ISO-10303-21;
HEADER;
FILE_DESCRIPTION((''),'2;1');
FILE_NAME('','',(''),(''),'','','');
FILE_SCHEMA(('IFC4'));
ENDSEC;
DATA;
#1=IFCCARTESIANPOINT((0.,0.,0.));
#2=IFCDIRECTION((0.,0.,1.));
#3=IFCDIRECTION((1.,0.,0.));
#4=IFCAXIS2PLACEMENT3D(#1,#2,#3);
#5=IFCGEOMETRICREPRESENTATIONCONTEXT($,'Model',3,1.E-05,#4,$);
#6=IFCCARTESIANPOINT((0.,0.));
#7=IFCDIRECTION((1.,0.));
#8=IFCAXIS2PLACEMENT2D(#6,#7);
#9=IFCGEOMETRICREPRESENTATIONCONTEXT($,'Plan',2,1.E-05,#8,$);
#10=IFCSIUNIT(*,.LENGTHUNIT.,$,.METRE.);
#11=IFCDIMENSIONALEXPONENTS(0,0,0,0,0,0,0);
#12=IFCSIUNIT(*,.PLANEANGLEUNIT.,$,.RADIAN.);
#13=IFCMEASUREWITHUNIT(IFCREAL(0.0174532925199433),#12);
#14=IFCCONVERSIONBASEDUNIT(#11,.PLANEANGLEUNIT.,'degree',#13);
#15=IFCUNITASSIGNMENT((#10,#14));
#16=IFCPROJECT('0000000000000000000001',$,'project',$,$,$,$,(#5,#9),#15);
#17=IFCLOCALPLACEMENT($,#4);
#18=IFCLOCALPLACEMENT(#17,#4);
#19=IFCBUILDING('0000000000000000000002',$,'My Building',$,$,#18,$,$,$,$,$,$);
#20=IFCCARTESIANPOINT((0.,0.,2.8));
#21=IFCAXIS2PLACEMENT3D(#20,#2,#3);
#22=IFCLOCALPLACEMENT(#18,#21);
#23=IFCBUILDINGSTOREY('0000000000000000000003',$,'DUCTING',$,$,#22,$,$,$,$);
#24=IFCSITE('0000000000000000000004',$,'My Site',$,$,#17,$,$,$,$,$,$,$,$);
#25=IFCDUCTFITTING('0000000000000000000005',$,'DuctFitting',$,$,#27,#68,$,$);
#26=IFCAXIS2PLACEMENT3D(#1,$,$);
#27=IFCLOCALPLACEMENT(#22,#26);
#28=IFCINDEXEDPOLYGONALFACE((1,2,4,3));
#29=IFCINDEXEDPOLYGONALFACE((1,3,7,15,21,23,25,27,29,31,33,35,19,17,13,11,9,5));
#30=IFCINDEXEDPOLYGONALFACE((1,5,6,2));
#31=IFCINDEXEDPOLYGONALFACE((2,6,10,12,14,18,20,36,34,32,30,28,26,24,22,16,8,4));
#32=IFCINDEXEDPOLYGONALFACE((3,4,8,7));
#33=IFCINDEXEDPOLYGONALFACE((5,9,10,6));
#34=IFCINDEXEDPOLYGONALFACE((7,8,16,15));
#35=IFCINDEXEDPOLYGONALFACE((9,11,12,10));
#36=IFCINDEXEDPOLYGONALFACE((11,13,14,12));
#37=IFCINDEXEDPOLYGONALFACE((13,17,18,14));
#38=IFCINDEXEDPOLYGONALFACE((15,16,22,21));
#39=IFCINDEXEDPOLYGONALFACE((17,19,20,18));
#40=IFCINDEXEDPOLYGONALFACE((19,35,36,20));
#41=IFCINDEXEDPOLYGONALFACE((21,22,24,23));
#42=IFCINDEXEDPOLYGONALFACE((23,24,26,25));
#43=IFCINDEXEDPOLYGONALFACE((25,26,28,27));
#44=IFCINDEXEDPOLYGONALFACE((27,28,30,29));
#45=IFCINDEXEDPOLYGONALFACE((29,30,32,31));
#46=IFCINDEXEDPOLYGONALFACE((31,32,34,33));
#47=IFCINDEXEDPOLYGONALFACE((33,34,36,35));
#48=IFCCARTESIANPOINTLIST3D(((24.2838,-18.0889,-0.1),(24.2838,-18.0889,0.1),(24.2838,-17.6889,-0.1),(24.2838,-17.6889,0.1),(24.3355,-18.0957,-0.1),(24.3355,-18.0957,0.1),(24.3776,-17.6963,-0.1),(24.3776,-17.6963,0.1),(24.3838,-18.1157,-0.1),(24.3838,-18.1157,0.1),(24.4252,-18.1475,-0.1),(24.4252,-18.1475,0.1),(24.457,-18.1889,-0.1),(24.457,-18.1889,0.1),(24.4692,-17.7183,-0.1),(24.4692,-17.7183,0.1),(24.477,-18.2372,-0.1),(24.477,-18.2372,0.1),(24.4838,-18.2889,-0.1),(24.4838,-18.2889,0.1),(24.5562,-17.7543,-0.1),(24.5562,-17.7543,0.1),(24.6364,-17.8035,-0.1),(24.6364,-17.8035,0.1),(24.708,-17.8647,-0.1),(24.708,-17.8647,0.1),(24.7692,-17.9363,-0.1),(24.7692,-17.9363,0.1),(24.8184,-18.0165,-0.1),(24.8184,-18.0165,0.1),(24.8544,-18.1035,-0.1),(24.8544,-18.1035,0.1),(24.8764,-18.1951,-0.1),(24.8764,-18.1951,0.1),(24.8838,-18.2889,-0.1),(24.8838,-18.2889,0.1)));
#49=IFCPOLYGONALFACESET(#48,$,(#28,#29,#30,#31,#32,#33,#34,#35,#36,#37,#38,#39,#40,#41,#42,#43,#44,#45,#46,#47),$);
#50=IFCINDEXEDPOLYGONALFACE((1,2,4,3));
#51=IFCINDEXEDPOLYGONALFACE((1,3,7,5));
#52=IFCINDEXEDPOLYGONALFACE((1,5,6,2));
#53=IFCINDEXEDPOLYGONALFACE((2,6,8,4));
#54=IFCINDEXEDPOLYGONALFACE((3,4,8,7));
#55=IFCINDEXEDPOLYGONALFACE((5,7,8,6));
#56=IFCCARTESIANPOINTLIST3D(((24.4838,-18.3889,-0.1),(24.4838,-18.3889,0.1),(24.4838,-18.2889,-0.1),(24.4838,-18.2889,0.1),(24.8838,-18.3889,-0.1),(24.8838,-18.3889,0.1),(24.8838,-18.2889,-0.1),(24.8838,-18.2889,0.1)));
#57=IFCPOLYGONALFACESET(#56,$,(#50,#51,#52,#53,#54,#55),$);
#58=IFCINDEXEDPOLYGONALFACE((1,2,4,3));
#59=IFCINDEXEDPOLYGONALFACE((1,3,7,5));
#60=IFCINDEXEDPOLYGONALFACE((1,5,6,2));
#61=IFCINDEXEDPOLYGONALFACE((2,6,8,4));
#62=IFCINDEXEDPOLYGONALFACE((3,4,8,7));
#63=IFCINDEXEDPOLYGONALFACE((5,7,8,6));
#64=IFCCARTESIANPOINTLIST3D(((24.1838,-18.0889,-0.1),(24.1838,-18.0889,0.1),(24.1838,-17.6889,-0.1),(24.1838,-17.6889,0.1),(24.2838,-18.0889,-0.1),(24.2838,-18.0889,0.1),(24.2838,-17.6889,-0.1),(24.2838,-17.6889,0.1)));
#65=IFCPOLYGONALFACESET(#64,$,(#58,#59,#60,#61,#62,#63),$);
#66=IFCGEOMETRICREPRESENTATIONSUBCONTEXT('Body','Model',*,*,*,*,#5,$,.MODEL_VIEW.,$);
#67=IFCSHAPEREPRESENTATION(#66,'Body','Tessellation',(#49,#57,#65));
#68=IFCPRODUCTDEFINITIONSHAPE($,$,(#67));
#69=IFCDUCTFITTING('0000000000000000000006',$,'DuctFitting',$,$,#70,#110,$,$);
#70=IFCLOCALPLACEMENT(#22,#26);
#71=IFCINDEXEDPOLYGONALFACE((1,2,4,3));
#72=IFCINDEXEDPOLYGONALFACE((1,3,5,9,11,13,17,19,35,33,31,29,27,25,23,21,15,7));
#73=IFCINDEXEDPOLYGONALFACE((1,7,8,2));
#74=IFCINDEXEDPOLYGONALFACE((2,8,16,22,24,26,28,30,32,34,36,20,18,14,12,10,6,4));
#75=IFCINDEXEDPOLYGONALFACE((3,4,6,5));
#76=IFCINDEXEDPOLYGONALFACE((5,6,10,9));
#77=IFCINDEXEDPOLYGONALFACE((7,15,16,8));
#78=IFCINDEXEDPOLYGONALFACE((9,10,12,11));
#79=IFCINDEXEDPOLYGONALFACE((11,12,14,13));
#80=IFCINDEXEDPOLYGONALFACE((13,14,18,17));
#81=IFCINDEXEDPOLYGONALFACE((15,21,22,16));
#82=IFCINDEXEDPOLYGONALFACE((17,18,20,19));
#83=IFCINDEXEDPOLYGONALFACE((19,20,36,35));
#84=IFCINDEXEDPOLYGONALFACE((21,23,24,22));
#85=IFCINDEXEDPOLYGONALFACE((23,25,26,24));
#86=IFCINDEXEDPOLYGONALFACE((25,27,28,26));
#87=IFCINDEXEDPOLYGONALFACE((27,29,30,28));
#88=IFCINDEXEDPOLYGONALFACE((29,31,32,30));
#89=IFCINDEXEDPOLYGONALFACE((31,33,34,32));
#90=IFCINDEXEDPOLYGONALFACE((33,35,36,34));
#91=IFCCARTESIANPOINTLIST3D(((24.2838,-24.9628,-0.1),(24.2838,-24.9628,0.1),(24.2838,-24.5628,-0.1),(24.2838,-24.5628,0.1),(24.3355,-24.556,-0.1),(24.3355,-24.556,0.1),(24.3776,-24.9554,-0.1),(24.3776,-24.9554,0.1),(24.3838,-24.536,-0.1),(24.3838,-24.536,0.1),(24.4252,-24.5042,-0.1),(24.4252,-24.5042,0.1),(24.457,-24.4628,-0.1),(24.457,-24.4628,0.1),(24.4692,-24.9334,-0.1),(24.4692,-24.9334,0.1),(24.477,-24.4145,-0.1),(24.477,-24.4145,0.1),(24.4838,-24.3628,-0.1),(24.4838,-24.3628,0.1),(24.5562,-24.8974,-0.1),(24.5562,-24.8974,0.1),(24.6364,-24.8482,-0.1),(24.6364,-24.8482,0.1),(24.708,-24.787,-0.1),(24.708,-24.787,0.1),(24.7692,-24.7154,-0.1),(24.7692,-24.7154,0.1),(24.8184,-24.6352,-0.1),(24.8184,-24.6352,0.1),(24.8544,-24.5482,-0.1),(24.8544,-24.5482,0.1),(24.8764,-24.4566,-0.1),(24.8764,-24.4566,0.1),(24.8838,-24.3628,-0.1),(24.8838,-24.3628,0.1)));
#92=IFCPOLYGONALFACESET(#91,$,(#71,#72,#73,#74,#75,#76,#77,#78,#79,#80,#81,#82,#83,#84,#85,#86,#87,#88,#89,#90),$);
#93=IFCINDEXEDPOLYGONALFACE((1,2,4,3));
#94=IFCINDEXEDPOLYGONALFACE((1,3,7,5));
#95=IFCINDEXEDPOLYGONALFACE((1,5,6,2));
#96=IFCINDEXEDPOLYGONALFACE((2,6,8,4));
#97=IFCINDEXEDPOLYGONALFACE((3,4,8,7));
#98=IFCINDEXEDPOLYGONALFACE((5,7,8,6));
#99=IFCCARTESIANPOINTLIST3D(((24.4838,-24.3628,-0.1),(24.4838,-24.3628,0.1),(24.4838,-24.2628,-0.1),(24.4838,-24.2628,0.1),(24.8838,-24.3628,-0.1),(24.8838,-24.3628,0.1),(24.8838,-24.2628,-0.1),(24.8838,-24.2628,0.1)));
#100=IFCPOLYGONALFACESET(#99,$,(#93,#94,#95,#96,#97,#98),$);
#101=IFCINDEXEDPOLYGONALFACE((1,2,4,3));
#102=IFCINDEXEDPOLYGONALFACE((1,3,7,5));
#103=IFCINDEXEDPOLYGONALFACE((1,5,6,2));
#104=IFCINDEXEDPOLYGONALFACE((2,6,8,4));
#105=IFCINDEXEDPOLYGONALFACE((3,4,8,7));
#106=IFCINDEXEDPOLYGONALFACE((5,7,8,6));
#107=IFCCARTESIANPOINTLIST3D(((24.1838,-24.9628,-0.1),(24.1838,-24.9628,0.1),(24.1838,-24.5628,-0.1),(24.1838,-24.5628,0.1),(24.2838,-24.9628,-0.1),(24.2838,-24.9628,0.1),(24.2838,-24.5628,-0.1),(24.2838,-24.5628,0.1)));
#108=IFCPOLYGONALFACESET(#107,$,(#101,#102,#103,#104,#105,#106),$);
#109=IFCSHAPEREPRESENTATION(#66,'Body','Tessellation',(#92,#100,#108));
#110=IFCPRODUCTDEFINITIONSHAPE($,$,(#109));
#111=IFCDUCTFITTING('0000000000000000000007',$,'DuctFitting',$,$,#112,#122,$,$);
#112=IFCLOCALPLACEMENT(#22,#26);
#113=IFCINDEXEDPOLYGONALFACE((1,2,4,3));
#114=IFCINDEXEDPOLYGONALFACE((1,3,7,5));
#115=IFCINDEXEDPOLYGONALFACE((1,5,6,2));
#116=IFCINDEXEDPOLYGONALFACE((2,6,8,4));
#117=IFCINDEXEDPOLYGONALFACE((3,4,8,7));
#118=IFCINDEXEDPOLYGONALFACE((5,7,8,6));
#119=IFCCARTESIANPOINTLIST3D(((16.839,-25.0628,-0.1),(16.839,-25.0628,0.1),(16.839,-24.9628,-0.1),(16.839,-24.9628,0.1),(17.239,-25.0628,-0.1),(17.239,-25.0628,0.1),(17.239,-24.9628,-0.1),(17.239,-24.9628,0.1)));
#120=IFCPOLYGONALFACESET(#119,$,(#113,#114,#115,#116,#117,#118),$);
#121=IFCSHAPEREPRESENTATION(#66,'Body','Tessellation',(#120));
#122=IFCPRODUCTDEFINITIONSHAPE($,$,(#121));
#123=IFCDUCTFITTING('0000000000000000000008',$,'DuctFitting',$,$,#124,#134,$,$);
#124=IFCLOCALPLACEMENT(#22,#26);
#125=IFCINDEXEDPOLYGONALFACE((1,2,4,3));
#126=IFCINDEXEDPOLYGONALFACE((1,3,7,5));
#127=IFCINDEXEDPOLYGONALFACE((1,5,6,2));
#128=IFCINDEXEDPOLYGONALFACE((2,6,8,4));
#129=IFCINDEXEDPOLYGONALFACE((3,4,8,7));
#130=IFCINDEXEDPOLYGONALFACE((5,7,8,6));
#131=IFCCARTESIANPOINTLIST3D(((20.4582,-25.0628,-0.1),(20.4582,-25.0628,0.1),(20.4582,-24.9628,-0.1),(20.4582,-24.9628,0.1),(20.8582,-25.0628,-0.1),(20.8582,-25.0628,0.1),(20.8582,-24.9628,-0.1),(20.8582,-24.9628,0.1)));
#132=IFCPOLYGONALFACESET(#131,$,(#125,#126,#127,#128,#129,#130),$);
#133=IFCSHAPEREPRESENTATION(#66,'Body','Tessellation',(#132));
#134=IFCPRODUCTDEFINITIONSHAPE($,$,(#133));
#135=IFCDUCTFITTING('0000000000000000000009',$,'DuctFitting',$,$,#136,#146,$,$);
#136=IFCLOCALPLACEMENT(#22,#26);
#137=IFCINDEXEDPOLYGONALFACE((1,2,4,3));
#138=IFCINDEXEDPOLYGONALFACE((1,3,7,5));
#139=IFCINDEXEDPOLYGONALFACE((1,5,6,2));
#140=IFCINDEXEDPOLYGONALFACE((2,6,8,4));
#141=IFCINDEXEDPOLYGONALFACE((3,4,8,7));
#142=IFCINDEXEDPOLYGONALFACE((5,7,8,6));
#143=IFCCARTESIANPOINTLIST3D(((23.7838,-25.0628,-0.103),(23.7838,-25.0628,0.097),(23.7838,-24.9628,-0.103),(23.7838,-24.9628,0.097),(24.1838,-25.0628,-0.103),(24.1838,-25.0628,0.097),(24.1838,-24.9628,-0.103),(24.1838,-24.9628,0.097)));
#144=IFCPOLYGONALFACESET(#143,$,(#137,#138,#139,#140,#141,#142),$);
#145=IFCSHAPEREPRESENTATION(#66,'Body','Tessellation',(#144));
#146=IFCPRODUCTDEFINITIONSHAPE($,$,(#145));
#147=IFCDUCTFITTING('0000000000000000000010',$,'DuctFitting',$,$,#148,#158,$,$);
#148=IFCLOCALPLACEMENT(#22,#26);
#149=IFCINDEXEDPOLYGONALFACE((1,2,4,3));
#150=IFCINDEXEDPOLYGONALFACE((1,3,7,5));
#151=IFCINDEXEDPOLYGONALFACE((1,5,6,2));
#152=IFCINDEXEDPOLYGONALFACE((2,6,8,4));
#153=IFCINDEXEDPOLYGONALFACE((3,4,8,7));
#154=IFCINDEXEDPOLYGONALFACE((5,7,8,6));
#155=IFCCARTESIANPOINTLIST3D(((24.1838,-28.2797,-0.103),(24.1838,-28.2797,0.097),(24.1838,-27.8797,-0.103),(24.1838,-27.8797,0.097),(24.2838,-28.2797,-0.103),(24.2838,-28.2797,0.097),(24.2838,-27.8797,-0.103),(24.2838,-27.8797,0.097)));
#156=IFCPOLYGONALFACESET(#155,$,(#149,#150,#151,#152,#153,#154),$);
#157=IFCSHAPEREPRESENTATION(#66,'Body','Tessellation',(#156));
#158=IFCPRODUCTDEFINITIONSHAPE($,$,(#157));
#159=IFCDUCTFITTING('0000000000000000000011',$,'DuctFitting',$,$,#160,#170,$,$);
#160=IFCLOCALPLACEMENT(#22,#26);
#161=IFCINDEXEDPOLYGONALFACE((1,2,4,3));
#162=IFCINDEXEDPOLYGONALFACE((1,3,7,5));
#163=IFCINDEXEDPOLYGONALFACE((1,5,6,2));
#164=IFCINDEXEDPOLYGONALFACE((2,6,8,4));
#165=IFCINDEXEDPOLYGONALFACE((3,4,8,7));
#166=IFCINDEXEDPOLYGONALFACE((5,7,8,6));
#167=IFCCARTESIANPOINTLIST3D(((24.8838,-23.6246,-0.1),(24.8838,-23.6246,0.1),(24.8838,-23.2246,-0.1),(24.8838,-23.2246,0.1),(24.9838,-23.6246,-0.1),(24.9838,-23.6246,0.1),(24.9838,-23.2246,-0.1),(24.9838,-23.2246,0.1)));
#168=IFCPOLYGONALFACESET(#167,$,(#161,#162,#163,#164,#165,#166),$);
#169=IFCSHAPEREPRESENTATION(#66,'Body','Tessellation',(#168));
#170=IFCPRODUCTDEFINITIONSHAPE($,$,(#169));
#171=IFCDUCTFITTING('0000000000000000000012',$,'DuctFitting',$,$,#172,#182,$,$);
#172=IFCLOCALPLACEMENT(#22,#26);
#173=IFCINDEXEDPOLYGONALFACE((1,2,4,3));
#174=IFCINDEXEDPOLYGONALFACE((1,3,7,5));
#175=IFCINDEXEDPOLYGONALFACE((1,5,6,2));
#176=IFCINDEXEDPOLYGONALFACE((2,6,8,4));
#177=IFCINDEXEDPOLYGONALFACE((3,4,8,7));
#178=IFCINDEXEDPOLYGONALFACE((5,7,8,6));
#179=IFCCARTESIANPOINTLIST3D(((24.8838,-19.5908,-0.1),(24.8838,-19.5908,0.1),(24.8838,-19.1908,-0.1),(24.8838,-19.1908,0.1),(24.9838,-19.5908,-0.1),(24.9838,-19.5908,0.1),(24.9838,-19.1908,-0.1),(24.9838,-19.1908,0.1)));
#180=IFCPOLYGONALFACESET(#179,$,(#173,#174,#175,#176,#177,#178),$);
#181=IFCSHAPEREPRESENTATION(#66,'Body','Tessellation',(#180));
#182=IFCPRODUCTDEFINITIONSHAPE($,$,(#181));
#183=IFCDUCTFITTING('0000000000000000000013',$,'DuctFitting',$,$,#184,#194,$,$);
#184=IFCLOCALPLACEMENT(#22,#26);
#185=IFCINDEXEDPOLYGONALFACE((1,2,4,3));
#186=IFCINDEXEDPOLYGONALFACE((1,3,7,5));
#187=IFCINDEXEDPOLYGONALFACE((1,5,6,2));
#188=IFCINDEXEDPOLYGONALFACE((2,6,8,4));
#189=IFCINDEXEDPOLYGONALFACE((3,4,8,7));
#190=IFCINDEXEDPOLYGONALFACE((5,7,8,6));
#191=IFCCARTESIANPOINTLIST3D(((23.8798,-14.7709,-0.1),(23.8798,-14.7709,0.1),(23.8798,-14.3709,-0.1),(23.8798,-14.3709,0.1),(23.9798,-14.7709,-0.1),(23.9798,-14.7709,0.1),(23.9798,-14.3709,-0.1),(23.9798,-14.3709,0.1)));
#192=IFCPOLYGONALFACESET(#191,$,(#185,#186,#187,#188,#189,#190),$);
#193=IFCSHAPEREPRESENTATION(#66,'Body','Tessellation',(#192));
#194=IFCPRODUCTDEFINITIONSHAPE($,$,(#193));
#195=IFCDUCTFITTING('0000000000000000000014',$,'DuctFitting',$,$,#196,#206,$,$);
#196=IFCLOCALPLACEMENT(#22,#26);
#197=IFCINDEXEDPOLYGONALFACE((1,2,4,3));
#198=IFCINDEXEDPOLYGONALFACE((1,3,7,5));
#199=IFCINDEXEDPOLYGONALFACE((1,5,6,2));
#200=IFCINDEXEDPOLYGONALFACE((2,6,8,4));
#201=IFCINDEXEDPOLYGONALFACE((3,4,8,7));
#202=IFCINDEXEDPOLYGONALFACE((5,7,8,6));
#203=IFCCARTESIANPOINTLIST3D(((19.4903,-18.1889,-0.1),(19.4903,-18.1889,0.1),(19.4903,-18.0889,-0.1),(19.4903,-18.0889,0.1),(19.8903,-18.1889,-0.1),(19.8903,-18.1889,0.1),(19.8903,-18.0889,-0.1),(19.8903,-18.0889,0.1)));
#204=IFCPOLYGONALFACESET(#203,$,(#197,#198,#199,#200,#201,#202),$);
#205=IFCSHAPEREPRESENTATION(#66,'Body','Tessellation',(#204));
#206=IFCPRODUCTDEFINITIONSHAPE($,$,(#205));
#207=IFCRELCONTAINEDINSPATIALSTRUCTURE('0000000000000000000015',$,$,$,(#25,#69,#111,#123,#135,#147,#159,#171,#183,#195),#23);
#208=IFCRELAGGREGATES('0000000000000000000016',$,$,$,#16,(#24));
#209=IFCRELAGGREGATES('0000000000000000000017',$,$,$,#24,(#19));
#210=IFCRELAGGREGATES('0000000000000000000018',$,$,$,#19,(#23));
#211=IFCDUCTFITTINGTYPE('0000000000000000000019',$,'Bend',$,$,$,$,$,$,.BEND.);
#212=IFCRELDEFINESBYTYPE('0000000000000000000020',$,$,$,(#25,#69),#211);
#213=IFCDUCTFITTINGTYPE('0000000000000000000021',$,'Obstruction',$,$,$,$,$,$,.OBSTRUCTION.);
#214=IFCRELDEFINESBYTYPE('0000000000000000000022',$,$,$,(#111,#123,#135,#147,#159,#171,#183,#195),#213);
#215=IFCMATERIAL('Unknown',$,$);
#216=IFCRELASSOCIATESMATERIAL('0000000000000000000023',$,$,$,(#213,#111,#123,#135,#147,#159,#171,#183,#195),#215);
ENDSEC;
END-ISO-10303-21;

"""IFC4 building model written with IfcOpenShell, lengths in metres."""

from ifc_helpers import new_model, entity, si_unit, converted_unit, frame, origin_with_axes, origin_2d_with_axis, place, context, subcontext, project, spatial, line, arc, indexed_curve, rectangle, outline, extrude, source, transform, mapped, material, material_profile, profile_set, profile_usage, type_object, type_shapes, element, save


model = new_model("IFC4")

# Units and contexts
model_context = context("Model", 3, precision=1e-05, world=origin_with_axes())
plan_context = context("Plan", 2, precision=1e-05, world=origin_2d_with_axis())
body_context = subcontext(model_context, "Body", "Model", "MODEL_VIEW")
ifc_project = project(units=[si_unit("LENGTHUNIT", "METRE"), converted_unit("PLANEANGLEUNIT", "degree", entity("IfcReal", 0.0174532925199433), si_unit("PLANEANGLEUNIT", "RADIAN"), dimensions=[0, 0, 0, 0, 0, 0, 0])], contexts=[model_context, plan_context])

# Site, building, storey
site_placement = place(None, origin_with_axes())
site = spatial("IfcSite", under=ifc_project, at=site_placement, Name="My Site")
building_placement = place(site_placement, origin_with_axes())
building = spatial("IfcBuilding", under=site, at=building_placement, Name="My Building")
storey_placement = place(building_placement, frame((0.0, 0.0, 2.8), z_axis=(0.0, 0.0, 1.0), x_axis=(1.0, 0.0, 0.0)))
storey = spatial("IfcBuildingStorey", under=building, at=storey_placement, Name="DUCTING")

# Shared definitions
ifc_material = material(Name="Unknown")

# Duct fittings
duct_fitting_type_1 = type_object("IfcDuctFittingType", Name="Bend", PredefinedType="BEND")
shared_shape = source(origin_with_axes(), body_context, "Body", "SweptSolid", [
    extrude(outline(indexed_curve([(-0.2, 0.0), (-0.2586, -0.1414), (-0.4, -0.2), (-0.4, -0.6), (0.0243, -0.4243), (0.2, 0.0)], segments=[arc(1, 2, 3), line(3, 4), arc(4, 5, 6), line(6, 1)])), frame((0.0, -0.1, -0.1), z_axis=(0.0, -1.0, 0.0), x_axis=(1.0, 0.0, 0.0)), (0.0, 0.0, -1.0), 0.2),
    extrude(rectangle(XDim=0.4, YDim=0.2), origin_with_axes(), (0.0, 0.0, -1.0), 0.1),
    extrude(rectangle(XDim=0.4, YDim=0.2), frame((-0.4, 0.0, -0.5), z_axis=(-1.0, 0.0, 0.0), x_axis=(0.0, 0.0, -1.0)), (0.0, 0.0, 1.0), 0.1),
])
type_shapes(duct_fitting_type_1, [shared_shape])
for number, where, z_axis, x_axis, name in (
    (1, (24.6838, -18.3889, 0.0), (0.0, -1.0, 0.0), (1.0, 0.0, 0.0), "DuctFitting"),
    (2, (24.6838, -24.2628, 0.0), (0.0, 1.0, 0.0), (1.0, 0.0, 0.0), "DuctFitting"),
):
    element("IfcDuctFitting", number, at=place(storey_placement, frame(where, z_axis=z_axis, x_axis=x_axis)), inside=storey, type_object=duct_fitting_type_1, Name=name, context=body_context, shape_type="MappedRepresentation", body=[
        mapped(shared_shape, transform((0.0, 0.0, 0.0), x_axis=(1.0, 0.0, 0.0), y_axis=(0.0, 1.0, 0.0), z_axis=(0.0, 0.0, 1.0), scale=1.0)),
    ])
ifc_material_profile_1 = material_profile(ifc_material, rectangle(XDim=0.4, YDim=0.2))
ifc_profile_set_1 = profile_set([ifc_material_profile_1])
ifc_profile_usage_1 = profile_usage(ifc_profile_set_1, cardinal=5)
duct_fitting_type_2 = type_object("IfcDuctFittingType", Name="Obstruction", PredefinedType="OBSTRUCTION", material=ifc_profile_set_1)
duct_fitting_1_placement = place(storey_placement, frame((17.039, -24.9628, 0.0), z_axis=(0.0, -1.0, 0.0), x_axis=(1.0, 0.0, 0.0)))
element("IfcDuctFitting", 3, at=duct_fitting_1_placement, inside=storey, type_object=duct_fitting_type_2, material=ifc_profile_usage_1, Name="DuctFitting", context=body_context, shape_type="SweptSolid", body=[
    extrude(rectangle(XDim=0.4, YDim=0.2), origin_with_axes(), (0.0, 0.0, 1.0), 0.1),
])
ifc_profile_usage_2 = profile_usage(ifc_profile_set_1, cardinal=5)
duct_fitting_2_placement = place(storey_placement, frame((20.6582, -24.9628, 0.0), z_axis=(0.0, -1.0, 0.0), x_axis=(1.0, 0.0, 0.0)))
element("IfcDuctFitting", 4, at=duct_fitting_2_placement, inside=storey, type_object=duct_fitting_type_2, material=ifc_profile_usage_2, Name="DuctFitting", context=body_context, shape_type="SweptSolid", body=[
    extrude(rectangle(XDim=0.4, YDim=0.2), origin_with_axes(), (0.0, 0.0, 1.0), 0.1),
])
ifc_profile_usage_3 = profile_usage(ifc_profile_set_1, cardinal=5)
duct_fitting_3_placement = place(storey_placement, frame((23.9838, -24.9628, -0.003), z_axis=(0.0, -1.0, 0.0), x_axis=(1.0, 0.0, 0.0)))
element("IfcDuctFitting", 5, at=duct_fitting_3_placement, inside=storey, type_object=duct_fitting_type_2, material=ifc_profile_usage_3, Name="DuctFitting", context=body_context, shape_type="SweptSolid", body=[
    extrude(rectangle(XDim=0.4, YDim=0.2), origin_with_axes(), (0.0, 0.0, 1.0), 0.1),
])
ifc_profile_usage_4 = profile_usage(ifc_profile_set_1, cardinal=5)
duct_fitting_4_placement = place(storey_placement, frame((24.1838, -28.0797, -0.003), z_axis=(1.0, 0.0, 0.0), x_axis=(0.0, 1.0, 0.0)))
element("IfcDuctFitting", 6, at=duct_fitting_4_placement, inside=storey, type_object=duct_fitting_type_2, material=ifc_profile_usage_4, Name="DuctFitting", context=body_context, shape_type="SweptSolid", body=[
    extrude(rectangle(XDim=0.4, YDim=0.2), origin_with_axes(), (0.0, 0.0, 1.0), 0.1),
])
ifc_profile_usage_5 = profile_usage(ifc_profile_set_1, cardinal=5)
duct_fitting_5_placement = place(storey_placement, frame((24.8838, -23.4246, 0.0), z_axis=(1.0, 0.0, 0.0), x_axis=(0.0, 1.0, 0.0)))
element("IfcDuctFitting", 7, at=duct_fitting_5_placement, inside=storey, type_object=duct_fitting_type_2, material=ifc_profile_usage_5, Name="DuctFitting", context=body_context, shape_type="SweptSolid", body=[
    extrude(rectangle(XDim=0.4, YDim=0.2), origin_with_axes(), (0.0, 0.0, 1.0), 0.1),
])
ifc_profile_usage_6 = profile_usage(ifc_profile_set_1, cardinal=5)
duct_fitting_6_placement = place(storey_placement, frame((24.8838, -19.3908, 0.0), z_axis=(1.0, 0.0, 0.0), x_axis=(0.0, 1.0, 0.0)))
element("IfcDuctFitting", 8, at=duct_fitting_6_placement, inside=storey, type_object=duct_fitting_type_2, material=ifc_profile_usage_6, Name="DuctFitting", context=body_context, shape_type="SweptSolid", body=[
    extrude(rectangle(XDim=0.4, YDim=0.2), origin_with_axes(), (0.0, 0.0, 1.0), 0.1),
])
ifc_profile_usage_7 = profile_usage(ifc_profile_set_1, cardinal=5)
duct_fitting_7_placement = place(storey_placement, frame((23.8798, -14.5709, 0.0), z_axis=(1.0, 0.0, 0.0), x_axis=(0.0, 1.0, 0.0)))
element("IfcDuctFitting", 9, at=duct_fitting_7_placement, inside=storey, type_object=duct_fitting_type_2, material=ifc_profile_usage_7, Name="DuctFitting", context=body_context, shape_type="SweptSolid", body=[
    extrude(rectangle(XDim=0.4, YDim=0.2), origin_with_axes(), (0.0, 0.0, 1.0), 0.1),
])
ifc_profile_usage_8 = profile_usage(ifc_profile_set_1, cardinal=5)
duct_fitting_8_placement = place(storey_placement, frame((19.6903, -18.0889, 0.0), z_axis=(0.0, -1.0, 0.0), x_axis=(1.0, 0.0, 0.0)))
element("IfcDuctFitting", 10, at=duct_fitting_8_placement, inside=storey, type_object=duct_fitting_type_2, material=ifc_profile_usage_8, Name="DuctFitting", context=body_context, shape_type="SweptSolid", body=[
    extrude(rectangle(XDim=0.4, YDim=0.2), origin_with_axes(), (0.0, 0.0, 1.0), 0.1),
])

save(model, "model.ifc")
